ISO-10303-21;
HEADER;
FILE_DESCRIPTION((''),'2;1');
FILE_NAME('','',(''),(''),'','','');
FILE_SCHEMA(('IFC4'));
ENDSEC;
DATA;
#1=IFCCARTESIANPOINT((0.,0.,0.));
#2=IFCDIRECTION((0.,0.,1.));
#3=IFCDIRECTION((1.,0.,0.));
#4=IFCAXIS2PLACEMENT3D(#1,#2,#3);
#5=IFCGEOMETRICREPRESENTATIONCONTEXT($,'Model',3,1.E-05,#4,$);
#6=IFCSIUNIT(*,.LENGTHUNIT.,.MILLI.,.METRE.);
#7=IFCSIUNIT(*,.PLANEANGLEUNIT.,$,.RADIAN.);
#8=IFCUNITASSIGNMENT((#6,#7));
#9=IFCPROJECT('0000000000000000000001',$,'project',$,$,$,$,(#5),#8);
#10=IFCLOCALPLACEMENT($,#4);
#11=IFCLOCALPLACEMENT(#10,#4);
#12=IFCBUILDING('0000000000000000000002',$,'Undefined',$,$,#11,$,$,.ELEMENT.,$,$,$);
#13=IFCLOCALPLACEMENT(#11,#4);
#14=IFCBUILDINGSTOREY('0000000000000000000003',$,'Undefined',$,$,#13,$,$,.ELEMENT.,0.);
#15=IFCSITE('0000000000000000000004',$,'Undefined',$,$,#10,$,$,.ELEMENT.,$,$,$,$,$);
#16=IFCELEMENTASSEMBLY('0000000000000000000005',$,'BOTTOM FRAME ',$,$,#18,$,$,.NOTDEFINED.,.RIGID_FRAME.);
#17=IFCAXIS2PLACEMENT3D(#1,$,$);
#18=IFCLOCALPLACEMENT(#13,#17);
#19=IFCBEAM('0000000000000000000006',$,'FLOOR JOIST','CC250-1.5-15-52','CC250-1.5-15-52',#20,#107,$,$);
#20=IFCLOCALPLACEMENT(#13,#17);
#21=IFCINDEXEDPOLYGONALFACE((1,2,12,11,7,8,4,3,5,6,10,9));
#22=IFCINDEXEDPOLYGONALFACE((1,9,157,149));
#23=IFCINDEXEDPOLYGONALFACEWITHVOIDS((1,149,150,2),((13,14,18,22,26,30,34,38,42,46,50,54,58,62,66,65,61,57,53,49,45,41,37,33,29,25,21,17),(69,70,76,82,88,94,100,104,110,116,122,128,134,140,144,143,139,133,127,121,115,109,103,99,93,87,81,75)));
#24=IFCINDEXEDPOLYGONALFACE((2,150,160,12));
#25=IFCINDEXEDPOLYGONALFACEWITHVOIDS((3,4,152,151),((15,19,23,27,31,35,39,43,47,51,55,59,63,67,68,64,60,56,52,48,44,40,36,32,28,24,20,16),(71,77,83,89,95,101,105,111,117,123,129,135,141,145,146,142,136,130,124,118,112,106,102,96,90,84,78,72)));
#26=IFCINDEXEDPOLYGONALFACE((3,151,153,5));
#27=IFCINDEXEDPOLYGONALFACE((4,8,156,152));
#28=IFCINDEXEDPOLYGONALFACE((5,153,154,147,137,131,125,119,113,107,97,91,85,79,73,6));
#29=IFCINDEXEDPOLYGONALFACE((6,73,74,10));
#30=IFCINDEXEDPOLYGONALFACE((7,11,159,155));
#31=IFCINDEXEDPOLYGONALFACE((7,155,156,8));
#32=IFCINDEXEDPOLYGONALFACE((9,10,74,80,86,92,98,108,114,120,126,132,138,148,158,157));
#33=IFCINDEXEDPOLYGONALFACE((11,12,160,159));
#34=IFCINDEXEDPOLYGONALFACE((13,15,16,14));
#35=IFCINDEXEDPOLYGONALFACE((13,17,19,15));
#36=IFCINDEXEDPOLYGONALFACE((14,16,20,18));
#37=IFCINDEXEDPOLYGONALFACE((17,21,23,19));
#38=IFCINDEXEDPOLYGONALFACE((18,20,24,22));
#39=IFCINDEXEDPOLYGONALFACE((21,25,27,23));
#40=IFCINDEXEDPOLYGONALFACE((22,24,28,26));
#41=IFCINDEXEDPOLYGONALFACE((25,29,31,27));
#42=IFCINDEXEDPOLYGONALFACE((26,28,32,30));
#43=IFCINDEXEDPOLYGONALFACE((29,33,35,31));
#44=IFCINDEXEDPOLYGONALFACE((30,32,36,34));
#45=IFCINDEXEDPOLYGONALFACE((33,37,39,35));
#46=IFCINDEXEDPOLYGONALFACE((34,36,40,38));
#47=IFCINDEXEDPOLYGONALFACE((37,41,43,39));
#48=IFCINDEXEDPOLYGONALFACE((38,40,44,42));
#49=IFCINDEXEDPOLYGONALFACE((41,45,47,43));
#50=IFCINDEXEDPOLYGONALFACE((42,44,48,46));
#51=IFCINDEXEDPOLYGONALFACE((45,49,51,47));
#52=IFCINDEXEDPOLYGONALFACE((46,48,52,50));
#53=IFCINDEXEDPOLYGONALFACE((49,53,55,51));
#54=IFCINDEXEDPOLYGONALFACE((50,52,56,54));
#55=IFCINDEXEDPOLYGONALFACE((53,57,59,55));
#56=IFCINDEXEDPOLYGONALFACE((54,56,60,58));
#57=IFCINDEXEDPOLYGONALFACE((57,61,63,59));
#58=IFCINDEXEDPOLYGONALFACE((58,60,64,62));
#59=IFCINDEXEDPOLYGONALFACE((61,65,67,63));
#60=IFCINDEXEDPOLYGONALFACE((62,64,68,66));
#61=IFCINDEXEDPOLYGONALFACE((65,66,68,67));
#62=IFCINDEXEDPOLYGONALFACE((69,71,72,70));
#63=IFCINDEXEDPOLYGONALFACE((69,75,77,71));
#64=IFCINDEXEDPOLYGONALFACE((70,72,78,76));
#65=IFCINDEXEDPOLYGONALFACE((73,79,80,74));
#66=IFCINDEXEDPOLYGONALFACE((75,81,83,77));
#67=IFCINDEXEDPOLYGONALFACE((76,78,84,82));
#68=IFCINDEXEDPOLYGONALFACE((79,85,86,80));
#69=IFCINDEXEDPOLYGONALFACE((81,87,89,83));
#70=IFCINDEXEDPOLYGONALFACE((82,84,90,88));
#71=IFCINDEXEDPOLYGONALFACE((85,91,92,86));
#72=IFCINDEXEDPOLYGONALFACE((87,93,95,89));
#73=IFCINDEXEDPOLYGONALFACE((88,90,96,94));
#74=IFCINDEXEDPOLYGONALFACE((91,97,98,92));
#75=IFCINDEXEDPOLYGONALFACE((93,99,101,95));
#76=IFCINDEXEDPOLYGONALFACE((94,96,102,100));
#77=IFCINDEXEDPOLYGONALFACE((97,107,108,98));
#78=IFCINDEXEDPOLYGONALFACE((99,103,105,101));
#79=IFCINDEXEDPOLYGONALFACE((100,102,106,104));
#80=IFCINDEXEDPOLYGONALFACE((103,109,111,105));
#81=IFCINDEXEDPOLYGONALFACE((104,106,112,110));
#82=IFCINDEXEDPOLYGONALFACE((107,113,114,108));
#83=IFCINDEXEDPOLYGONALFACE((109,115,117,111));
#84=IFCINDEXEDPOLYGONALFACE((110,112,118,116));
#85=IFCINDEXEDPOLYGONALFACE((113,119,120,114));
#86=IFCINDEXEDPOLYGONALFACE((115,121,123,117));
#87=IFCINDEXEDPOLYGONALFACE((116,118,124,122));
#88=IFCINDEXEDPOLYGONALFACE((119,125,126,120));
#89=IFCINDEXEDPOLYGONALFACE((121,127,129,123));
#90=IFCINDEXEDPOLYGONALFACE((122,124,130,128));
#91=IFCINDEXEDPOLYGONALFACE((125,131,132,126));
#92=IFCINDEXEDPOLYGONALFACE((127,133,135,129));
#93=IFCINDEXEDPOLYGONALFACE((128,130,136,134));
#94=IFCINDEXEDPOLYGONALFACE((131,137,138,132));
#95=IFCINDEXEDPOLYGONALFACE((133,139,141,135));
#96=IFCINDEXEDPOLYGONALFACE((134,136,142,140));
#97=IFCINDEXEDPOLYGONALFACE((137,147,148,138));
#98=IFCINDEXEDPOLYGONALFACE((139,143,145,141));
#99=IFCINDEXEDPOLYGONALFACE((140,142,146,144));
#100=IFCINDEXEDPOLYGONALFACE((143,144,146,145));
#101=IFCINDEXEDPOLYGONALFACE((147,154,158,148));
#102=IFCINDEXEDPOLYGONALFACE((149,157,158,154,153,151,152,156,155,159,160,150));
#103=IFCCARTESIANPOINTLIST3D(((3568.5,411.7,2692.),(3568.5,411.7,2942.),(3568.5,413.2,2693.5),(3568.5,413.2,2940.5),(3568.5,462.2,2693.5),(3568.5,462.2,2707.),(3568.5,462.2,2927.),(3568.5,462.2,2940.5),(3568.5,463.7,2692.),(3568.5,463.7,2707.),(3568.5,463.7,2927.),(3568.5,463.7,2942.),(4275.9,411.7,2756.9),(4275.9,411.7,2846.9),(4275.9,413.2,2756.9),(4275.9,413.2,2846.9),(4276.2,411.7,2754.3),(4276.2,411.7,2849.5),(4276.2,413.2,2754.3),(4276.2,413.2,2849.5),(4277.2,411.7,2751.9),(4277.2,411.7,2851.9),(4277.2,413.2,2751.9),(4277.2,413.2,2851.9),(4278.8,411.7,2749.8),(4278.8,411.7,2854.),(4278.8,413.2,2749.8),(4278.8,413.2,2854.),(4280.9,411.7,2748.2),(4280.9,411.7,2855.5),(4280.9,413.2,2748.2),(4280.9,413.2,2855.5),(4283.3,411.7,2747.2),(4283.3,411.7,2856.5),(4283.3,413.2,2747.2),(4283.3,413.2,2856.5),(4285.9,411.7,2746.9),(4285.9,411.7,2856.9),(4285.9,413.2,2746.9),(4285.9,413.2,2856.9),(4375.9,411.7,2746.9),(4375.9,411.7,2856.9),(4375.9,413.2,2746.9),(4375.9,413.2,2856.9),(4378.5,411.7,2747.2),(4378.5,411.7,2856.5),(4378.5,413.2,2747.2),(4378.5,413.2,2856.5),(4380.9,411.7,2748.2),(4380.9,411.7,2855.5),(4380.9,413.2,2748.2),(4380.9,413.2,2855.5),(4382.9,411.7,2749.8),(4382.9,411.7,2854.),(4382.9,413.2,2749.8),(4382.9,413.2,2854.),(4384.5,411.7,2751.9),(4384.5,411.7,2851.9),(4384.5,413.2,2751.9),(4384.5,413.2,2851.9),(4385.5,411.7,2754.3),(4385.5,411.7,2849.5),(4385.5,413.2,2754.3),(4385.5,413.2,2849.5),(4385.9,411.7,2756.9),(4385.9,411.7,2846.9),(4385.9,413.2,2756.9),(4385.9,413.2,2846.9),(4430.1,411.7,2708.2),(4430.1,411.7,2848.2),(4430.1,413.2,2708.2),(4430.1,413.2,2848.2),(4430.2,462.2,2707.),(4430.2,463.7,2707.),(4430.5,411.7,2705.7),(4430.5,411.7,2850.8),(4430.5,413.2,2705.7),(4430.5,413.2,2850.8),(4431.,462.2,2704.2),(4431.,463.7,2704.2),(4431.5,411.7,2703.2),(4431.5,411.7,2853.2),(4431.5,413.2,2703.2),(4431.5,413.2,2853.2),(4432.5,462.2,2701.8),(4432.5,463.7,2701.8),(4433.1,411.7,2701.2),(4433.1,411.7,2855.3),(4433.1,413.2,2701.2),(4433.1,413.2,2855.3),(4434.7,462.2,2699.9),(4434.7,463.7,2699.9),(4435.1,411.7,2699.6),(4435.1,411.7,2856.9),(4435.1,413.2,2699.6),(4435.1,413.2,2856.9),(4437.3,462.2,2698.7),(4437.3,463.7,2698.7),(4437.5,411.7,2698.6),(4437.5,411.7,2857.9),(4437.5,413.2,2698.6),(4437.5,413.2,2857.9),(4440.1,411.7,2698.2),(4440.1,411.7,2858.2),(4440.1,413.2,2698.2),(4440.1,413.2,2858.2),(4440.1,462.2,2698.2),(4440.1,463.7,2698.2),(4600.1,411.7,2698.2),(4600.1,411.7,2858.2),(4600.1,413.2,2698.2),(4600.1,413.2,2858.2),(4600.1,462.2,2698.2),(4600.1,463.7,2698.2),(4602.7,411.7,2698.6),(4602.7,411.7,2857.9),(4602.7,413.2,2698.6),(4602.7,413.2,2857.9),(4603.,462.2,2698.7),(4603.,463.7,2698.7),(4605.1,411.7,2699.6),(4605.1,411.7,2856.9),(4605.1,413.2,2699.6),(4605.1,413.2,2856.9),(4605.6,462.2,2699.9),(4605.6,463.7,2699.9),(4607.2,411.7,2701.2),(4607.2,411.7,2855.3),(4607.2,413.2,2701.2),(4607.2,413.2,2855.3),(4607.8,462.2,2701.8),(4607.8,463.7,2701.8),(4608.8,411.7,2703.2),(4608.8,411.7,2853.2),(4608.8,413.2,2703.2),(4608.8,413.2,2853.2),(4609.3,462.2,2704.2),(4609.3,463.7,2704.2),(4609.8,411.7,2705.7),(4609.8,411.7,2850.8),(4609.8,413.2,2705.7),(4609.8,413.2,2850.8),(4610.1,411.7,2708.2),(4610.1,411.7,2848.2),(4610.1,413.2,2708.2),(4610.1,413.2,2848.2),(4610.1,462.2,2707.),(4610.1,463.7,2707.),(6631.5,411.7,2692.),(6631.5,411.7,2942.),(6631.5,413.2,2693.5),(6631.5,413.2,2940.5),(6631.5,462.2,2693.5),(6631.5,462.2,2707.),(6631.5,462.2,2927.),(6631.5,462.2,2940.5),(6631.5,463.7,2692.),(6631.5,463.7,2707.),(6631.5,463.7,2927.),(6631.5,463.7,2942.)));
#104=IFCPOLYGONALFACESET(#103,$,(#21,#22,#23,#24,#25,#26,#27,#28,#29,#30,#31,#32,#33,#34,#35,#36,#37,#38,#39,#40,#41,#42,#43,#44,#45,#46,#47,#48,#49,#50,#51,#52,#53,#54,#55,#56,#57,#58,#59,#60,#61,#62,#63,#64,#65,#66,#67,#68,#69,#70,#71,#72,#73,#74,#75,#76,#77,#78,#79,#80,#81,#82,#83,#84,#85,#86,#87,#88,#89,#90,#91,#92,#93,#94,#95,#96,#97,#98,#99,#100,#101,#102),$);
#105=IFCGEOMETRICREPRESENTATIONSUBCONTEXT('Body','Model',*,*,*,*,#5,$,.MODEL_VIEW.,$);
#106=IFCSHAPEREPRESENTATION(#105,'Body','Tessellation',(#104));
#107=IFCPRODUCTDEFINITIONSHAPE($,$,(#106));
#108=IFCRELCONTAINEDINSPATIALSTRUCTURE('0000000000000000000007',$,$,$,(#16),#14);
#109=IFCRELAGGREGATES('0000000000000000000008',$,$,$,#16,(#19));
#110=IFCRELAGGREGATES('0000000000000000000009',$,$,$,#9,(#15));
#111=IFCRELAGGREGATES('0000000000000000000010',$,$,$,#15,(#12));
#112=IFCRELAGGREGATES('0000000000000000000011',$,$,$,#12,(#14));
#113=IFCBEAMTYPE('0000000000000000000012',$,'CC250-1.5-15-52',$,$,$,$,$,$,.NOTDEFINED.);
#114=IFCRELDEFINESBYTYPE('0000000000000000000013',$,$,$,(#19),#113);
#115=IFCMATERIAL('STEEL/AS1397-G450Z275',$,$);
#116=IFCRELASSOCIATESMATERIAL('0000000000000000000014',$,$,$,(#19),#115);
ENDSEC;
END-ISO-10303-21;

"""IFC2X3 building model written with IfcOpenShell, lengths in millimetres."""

from ifc_helpers import new_model, si_unit, frame, frame_2d, origin_with_axes, origin_2d_with_axis, place, context, subcontext, project, spatial, polyline, circle_curve, parameter, trimmed, segment, composite_curve, c_section, outline, extrude, boolean, material, type_object, element, aggregate, save


model = new_model("IFC2X3")

# Units and contexts
model_context = context("Model", 3, precision=1e-05, world=origin_with_axes())
body_context = subcontext(model_context, "Body", "Model", "MODEL_VIEW")
ifc_project = project(units=[si_unit("LENGTHUNIT", "METRE", prefix="MILLI"), si_unit("PLANEANGLEUNIT", "RADIAN")], contexts=[model_context])

# Site, building, storey
site_placement = place(None, origin_with_axes())
site = spatial("IfcSite", under=ifc_project, at=site_placement, Name="Undefined", CompositionType="ELEMENT")
building_placement = place(site_placement, origin_with_axes())
building = spatial("IfcBuilding", under=site, at=building_placement, Name="Undefined", CompositionType="ELEMENT")
storey_placement = place(building_placement, origin_with_axes())
storey = spatial("IfcBuildingStorey", under=building, at=storey_placement, Name="Undefined", CompositionType="ELEMENT", Elevation=0.0)

# Element assembly, beam
assembly_1_placement = place(storey_placement, origin_with_axes())
assembly_1 = element("IfcElementAssembly", 1, at=assembly_1_placement, inside=storey, Name="BOTTOM FRAME ", AssemblyPlace="NOTDEFINED", PredefinedType="RIGID_FRAME")
ifc_material_1 = material(Name="STEEL/AS1397-G450Z275")
beam_type_1 = type_object("IfcBeamType", Name="CC250-1.5-15-52", PredefinedType="NOTDEFINED")
beam_1_placement = place(assembly_1_placement, frame((3568.5, 437.7, 2817.0), z_axis=(0.0, 0.0, -1.0), x_axis=(1.0, 0.0, 0.0)))
beam_1 = element("IfcBeam", 2, at=beam_1_placement, type_object=beam_type_1, material=ifc_material_1, Name="FLOOR JOIST", Description="CC250-1.5-15-52", ObjectType="CC250-1.5-15-52", context=body_context, shape_type="CSG", body=[
    boolean("DIFFERENCE", boolean("DIFFERENCE", extrude(c_section(Depth=250.0, Width=52.0, WallThickness=1.5, Girth=15.0, at=origin_2d_with_axis()), frame((3063.0, 0.0, 0.0), z_axis=(-1.0, 0.0, 0.0), x_axis=(0.0, -1.0, 0.0)), (0.0, 0.0, 1.0), 3063.0), extrude(outline(composite_curve([segment(trimmed(circle_curve(frame_2d((10.0, 10.0), x_axis=(-1.0, 0.0)), 10.0), [parameter(0.0)], [parameter(1.570796)], True, "PARAMETER"), True, "CONTINUOUS"), segment(polyline([(10.0, 0.0), (170.0, 0.0)]), True, "CONTINUOUS"), segment(trimmed(circle_curve(frame_2d((170.0, 10.0), x_axis=(0.0, -1.0)), 10.0), [parameter(0.0)], [parameter(1.570796)], True, "PARAMETER"), True, "CONTINUOUS"), segment(polyline([(180.0, 10.0), (180.0, 150.0)]), True, "CONTINUOUS"), segment(trimmed(circle_curve(frame_2d((170.0, 150.0), x_axis=(1.0, 0.0)), 10.0), [parameter(0.0)], [parameter(1.570796)], True, "PARAMETER"), True, "CONTINUOUS"), segment(polyline([(170.0, 160.0), (10.0, 160.0)]), True, "CONTINUOUS"), segment(trimmed(circle_curve(frame_2d((10.0, 150.0), x_axis=(0.0, 1.0)), 10.0), [parameter(0.0)], [parameter(1.570796)], True, "PARAMETER"), True, "CONTINUOUS"), segment(polyline([(0.0, 150.0), (0.0, 10.0)]), True, "CONTINUOUS")], self_intersect=True)), frame((861.6, 40.5, -41.2), z_axis=(0.0, -1.0, 0.0), x_axis=(1.0, 0.0, 0.0)), (0.0, 0.0, 1.0), 81.0)), extrude(outline(composite_curve([segment(trimmed(circle_curve(frame_2d((10.0, 10.0), x_axis=(-1.0, 0.0)), 10.0), [parameter(0.0)], [parameter(1.570796)], True, "PARAMETER"), True, "CONTINUOUS"), segment(polyline([(10.0, 0.0), (100.0, 0.0)]), True, "CONTINUOUS"), segment(trimmed(circle_curve(frame_2d((100.0, 10.0), x_axis=(0.0, -1.0)), 10.0), [parameter(0.0)], [parameter(1.570796)], True, "PARAMETER"), True, "CONTINUOUS"), segment(polyline([(110.0, 10.0), (110.0, 100.0)]), True, "CONTINUOUS"), segment(trimmed(circle_curve(frame_2d((100.0, 100.0), x_axis=(1.0, 0.0)), 10.0), [parameter(0.0)], [parameter(1.570796)], True, "PARAMETER"), True, "CONTINUOUS"), segment(polyline([(100.0, 110.0), (10.0, 110.0)]), True, "CONTINUOUS"), segment(trimmed(circle_curve(frame_2d((10.0, 100.0), x_axis=(0.0, 1.0)), 10.0), [parameter(0.0)], [parameter(1.570796)], True, "PARAMETER"), True, "CONTINUOUS"), segment(polyline([(0.0, 100.0), (0.0, 10.0)]), True, "CONTINUOUS")], self_intersect=True)), frame((707.4, 40.5, -39.9), z_axis=(0.0, -1.0, 0.0), x_axis=(1.0, 0.0, 0.0)), (0.0, 0.0, 1.0), 81.0)),
])

aggregate(assembly_1, [beam_1])

save(model, "model.ifc")
